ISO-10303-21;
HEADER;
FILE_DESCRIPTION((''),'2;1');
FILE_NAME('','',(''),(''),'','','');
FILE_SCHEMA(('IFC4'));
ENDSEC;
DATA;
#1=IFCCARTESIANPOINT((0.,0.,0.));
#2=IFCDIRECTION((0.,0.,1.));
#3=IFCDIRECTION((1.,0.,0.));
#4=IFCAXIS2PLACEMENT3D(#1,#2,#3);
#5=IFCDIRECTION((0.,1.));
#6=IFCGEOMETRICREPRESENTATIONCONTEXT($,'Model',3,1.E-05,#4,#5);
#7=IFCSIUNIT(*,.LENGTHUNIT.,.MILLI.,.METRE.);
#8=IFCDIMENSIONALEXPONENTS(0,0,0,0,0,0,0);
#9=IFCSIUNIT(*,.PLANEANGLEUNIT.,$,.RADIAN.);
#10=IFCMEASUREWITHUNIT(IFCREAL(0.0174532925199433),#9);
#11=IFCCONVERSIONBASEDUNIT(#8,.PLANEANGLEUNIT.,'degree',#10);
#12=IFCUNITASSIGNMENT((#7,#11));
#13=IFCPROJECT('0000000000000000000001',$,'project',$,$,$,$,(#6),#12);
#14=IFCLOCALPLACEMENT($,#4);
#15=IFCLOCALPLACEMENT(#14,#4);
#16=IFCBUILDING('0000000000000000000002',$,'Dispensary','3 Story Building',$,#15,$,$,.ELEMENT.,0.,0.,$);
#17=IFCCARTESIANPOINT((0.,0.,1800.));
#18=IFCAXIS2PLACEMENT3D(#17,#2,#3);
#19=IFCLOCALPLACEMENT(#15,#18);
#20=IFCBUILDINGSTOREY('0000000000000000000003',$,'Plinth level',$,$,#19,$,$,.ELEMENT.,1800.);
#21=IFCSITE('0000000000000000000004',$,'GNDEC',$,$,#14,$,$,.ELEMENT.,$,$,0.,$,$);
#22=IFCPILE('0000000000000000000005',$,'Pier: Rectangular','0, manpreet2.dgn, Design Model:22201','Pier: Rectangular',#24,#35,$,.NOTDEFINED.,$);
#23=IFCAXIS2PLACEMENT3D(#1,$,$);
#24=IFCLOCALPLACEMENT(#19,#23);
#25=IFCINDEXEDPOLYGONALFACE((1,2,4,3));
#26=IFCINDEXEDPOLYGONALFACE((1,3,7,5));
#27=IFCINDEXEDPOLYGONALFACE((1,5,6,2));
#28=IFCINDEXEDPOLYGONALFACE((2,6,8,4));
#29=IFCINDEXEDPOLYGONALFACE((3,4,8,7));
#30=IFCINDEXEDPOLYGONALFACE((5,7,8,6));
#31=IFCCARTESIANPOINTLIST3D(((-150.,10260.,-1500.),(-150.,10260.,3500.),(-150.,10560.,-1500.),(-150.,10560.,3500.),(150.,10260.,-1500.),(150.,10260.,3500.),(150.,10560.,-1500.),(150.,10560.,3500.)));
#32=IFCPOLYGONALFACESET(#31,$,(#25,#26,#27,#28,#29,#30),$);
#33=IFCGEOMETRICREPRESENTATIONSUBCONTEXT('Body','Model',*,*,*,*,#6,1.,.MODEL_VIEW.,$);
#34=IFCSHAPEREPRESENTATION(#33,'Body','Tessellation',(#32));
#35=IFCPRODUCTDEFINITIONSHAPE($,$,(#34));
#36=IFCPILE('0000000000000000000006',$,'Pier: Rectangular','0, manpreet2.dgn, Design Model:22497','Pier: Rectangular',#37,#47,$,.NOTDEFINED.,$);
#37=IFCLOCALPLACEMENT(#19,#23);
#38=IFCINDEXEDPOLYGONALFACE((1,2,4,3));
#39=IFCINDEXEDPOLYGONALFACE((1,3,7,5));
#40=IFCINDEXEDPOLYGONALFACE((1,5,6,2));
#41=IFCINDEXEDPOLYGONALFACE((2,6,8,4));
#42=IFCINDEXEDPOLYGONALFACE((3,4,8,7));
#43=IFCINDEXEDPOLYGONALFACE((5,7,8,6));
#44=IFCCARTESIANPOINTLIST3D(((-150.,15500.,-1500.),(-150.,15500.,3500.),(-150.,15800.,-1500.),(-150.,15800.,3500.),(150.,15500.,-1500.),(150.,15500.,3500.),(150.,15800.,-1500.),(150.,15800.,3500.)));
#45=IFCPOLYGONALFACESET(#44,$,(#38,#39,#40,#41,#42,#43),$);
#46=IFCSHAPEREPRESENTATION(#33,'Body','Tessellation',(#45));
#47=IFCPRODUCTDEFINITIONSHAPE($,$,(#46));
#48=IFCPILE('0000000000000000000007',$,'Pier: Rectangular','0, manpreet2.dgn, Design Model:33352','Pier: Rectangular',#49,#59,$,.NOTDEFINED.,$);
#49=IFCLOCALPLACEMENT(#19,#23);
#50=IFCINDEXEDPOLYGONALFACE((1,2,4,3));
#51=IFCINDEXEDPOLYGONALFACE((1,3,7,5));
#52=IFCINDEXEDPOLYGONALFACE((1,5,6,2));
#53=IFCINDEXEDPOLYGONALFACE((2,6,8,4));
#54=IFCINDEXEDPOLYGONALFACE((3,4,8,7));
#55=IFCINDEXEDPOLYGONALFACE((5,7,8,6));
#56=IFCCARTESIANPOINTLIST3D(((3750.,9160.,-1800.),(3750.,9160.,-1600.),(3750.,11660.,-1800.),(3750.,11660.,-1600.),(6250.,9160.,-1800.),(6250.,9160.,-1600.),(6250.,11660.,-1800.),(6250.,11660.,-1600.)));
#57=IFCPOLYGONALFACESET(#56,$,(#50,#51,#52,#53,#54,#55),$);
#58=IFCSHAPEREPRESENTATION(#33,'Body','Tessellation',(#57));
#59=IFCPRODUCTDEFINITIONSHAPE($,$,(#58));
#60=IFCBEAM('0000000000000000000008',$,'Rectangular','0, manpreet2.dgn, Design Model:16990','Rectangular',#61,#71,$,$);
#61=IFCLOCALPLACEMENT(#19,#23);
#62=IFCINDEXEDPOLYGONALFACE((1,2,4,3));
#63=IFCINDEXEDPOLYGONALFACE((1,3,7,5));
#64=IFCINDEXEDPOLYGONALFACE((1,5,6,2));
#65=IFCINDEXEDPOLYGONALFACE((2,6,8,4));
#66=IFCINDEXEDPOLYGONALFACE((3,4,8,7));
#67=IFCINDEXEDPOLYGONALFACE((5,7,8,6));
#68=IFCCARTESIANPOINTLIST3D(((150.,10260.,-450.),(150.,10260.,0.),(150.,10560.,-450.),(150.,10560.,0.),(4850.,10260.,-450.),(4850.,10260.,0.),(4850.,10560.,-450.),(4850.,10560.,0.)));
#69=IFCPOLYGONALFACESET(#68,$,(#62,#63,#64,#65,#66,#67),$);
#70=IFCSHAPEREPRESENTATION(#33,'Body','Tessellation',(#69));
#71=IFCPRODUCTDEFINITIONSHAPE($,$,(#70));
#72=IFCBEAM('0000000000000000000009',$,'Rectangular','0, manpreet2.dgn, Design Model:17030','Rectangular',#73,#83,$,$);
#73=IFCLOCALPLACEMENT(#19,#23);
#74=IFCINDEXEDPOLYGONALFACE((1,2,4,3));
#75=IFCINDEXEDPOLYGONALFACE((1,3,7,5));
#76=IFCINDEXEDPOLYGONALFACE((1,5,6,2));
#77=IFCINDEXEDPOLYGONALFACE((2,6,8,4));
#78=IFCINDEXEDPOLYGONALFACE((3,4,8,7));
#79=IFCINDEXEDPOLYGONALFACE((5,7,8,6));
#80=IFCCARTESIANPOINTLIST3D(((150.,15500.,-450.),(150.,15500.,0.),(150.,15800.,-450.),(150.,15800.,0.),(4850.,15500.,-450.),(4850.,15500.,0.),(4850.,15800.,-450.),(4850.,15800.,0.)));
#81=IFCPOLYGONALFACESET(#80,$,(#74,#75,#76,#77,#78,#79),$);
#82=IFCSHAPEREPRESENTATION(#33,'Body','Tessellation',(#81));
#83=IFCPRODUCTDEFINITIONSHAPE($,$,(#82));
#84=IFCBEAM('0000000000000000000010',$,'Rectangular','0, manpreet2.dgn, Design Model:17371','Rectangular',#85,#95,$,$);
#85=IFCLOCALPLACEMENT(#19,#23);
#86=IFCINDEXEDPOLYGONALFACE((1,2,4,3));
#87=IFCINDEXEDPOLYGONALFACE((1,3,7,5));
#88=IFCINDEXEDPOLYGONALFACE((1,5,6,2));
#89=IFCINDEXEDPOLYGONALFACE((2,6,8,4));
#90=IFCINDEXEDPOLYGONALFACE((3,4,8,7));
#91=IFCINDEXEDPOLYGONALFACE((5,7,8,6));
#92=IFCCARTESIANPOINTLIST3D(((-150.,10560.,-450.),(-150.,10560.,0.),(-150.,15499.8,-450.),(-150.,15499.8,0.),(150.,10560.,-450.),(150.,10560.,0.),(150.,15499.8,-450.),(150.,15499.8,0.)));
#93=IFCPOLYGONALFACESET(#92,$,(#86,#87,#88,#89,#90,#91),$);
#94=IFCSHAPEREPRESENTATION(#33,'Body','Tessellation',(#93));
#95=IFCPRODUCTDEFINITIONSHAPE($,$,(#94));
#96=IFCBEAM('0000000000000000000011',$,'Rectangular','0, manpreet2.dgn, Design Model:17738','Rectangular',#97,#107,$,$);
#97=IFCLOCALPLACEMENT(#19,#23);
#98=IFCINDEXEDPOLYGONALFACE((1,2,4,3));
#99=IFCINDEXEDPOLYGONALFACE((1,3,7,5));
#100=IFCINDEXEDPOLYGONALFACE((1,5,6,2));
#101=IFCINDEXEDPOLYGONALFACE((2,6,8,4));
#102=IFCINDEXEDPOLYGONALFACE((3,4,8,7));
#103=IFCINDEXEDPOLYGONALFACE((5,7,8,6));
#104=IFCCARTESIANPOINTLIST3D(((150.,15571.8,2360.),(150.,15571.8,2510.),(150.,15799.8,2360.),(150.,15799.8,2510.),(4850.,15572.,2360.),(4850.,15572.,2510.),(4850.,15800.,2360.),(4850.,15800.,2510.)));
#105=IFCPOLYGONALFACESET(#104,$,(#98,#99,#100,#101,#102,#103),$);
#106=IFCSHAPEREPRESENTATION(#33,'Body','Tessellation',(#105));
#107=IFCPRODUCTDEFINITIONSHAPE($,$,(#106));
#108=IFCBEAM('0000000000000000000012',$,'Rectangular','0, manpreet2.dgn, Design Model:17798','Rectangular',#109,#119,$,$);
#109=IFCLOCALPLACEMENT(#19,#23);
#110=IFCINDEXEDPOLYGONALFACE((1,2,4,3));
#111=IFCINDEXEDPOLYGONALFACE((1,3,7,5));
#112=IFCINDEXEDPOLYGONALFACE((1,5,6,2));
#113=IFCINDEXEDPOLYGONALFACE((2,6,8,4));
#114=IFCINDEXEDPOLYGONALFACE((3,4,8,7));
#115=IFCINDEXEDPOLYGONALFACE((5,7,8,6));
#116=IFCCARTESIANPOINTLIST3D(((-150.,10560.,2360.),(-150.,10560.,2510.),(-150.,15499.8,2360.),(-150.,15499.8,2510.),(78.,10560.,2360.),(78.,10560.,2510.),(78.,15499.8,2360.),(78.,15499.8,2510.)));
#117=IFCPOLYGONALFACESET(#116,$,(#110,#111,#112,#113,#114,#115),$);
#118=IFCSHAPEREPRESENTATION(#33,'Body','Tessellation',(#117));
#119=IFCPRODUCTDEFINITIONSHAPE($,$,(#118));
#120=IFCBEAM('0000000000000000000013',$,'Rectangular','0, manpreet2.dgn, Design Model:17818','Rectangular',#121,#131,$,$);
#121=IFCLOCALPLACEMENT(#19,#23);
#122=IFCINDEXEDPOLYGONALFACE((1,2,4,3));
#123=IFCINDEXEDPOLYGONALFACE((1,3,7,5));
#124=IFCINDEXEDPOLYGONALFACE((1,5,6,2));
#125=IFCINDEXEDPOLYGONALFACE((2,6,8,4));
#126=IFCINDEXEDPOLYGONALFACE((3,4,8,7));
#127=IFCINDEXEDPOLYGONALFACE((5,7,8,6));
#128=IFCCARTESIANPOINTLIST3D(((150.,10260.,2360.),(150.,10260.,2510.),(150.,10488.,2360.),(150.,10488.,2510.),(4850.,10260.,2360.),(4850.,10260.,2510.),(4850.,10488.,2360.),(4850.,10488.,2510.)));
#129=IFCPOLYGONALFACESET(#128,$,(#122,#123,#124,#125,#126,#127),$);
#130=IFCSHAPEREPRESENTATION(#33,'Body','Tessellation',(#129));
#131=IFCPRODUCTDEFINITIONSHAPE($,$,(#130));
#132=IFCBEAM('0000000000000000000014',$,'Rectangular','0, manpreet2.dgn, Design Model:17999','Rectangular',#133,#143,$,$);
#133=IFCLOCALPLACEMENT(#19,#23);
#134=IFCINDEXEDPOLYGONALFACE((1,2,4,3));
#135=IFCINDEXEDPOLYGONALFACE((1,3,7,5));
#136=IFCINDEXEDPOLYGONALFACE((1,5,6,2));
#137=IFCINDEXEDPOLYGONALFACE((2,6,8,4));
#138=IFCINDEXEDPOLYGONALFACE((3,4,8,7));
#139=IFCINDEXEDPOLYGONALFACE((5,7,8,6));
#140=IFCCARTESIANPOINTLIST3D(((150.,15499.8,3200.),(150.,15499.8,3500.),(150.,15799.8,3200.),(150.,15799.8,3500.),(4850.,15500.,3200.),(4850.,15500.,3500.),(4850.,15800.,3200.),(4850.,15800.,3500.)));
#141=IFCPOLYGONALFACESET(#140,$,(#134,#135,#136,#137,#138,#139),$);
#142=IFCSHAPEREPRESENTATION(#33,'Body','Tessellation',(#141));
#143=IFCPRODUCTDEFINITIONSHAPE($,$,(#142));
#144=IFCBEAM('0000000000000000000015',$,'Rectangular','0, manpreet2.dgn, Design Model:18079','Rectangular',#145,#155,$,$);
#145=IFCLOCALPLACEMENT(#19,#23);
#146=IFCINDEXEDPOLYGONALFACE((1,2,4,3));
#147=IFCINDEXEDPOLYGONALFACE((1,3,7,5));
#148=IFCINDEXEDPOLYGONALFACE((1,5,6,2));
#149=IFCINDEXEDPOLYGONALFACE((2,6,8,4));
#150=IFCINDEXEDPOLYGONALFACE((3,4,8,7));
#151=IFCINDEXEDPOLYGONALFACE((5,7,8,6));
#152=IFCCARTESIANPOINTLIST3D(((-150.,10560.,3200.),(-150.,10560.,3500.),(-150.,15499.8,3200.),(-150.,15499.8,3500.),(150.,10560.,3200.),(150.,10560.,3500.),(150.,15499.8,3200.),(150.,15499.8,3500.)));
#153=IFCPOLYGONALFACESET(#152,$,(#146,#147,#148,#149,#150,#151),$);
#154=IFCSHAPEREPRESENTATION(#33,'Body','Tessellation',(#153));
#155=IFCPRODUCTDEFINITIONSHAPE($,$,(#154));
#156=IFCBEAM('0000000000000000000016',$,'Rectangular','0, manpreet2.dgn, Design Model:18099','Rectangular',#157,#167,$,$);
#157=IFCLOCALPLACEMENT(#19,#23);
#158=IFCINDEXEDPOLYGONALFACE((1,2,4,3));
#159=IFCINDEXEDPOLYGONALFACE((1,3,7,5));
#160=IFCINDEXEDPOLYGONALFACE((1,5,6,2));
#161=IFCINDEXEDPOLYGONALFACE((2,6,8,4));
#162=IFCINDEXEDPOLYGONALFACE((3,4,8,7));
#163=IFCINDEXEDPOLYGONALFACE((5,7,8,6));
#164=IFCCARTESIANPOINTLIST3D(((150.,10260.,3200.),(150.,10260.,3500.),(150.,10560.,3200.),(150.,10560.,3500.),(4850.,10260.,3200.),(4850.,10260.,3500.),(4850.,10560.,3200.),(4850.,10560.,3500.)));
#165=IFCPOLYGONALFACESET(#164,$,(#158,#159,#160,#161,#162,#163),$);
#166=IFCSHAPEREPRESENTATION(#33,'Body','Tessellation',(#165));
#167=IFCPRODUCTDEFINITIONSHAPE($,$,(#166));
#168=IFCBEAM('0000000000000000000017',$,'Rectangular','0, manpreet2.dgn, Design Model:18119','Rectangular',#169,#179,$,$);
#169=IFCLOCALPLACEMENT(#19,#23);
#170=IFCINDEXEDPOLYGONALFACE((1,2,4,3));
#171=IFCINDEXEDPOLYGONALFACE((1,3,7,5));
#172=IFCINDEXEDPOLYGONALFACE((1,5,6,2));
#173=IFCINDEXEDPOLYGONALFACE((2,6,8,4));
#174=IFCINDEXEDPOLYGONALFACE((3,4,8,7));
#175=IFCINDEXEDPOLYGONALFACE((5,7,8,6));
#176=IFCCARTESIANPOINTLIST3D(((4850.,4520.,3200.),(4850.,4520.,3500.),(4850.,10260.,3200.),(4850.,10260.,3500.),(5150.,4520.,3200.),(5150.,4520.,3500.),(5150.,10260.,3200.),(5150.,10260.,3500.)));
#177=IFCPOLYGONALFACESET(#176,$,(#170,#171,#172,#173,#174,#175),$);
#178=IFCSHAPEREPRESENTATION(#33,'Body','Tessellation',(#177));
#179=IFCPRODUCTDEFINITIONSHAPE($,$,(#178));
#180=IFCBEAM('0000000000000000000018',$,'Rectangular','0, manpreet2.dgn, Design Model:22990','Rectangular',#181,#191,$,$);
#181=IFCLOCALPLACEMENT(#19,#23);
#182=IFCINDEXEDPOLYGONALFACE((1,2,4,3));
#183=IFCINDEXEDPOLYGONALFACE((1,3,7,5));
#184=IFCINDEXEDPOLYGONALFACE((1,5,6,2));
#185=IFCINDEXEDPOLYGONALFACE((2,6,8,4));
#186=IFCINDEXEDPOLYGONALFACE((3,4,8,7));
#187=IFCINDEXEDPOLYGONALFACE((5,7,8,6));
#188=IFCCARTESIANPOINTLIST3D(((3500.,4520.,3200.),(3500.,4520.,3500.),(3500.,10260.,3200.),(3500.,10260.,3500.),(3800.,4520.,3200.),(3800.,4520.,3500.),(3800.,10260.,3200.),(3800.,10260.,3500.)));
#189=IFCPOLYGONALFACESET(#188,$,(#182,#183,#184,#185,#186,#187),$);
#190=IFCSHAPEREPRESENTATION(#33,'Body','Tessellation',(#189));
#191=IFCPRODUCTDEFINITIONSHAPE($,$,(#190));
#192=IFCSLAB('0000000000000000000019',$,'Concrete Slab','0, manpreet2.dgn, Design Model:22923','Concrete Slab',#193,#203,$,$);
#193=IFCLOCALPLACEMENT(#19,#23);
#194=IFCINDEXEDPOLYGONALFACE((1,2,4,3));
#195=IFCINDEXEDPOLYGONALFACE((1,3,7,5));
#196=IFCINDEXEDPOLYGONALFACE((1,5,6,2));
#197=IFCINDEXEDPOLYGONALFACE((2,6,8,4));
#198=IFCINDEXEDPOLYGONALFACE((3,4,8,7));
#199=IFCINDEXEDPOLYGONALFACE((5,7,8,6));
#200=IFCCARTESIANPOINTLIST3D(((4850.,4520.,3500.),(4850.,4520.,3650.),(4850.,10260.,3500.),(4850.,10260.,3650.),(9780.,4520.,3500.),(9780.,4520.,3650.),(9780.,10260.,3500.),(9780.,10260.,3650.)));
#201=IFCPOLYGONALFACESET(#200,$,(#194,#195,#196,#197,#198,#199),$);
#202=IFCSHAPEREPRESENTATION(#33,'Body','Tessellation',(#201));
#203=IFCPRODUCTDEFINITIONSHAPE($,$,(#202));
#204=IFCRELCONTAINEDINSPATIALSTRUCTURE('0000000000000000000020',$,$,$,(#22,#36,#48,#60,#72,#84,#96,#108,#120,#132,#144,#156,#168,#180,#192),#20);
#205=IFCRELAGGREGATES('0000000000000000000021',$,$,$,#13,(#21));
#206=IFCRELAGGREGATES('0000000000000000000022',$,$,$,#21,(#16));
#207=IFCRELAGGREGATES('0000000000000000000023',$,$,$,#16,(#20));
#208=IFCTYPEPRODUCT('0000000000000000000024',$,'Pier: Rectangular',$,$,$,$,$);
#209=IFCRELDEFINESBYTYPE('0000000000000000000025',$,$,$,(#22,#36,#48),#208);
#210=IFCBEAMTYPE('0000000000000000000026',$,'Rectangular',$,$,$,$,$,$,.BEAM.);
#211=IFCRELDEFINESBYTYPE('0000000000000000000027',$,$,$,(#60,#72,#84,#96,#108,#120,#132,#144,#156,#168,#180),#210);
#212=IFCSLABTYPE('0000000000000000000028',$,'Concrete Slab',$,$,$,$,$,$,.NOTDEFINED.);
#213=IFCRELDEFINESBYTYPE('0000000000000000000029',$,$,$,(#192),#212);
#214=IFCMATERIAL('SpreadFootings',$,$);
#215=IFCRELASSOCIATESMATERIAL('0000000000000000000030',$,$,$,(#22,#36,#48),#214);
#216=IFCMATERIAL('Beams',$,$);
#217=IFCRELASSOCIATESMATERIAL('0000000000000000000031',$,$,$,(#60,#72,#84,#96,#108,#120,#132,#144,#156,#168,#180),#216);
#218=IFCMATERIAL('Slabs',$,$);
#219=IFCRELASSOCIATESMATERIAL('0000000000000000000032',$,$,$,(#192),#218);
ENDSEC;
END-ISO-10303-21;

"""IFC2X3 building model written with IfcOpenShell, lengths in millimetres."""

from ifc_helpers import new_model, entity, si_unit, converted_unit, direction, frame, frame_2d, origin_with_axes, place, context, subcontext, project, spatial, rectangle, extrude, material, type_object, element, save


model = new_model("IFC2X3")

# Units and contexts
model_context = context("Model", 3, precision=1e-05, world=origin_with_axes(), true_north=direction((0.0, 1.0)))
body_context = subcontext(model_context, "Body", "Model", "MODEL_VIEW", scale=1.0)
ifc_project = project(units=[si_unit("LENGTHUNIT", "METRE", prefix="MILLI"), converted_unit("PLANEANGLEUNIT", "degree", entity("IfcReal", 0.0174532925199433), si_unit("PLANEANGLEUNIT", "RADIAN"), dimensions=[0, 0, 0, 0, 0, 0, 0])], contexts=[model_context])

# Site, building, storey
site_placement = place(None, origin_with_axes())
site = spatial("IfcSite", under=ifc_project, at=site_placement, Name="GNDEC", CompositionType="ELEMENT", RefElevation=0.0)
building_placement = place(site_placement, origin_with_axes())
building = spatial("IfcBuilding", under=site, at=building_placement, Name="Dispensary", Description="3 Story Building", CompositionType="ELEMENT", ElevationOfRefHeight=0.0, ElevationOfTerrain=0.0)
storey_placement = place(building_placement, frame((0.0, 0.0, 1800.0), z_axis=(0.0, 0.0, 1.0), x_axis=(1.0, 0.0, 0.0)))
storey = spatial("IfcBuildingStorey", under=building, at=storey_placement, Name="Plinth level", CompositionType="ELEMENT", Elevation=1800.0)

# Piles
ifc_material_1 = material(Name="SpreadFootings")
type_product = type_object("IfcTypeProduct", Name="Pier: Rectangular")
for number, where, z_axis, x_axis, name, description in (
    (1, (-150.0, 10560.0, -1500.0), (0.0, 0.0, 1.0), (0.0, -1.0, 0.0), "Pier: Rectangular", "0, manpreet2.dgn, Design Model:22201"),
    (2, (-150.0, 15800.0, -1500.0), (0.0, 0.0, 1.0), (0.0, -1.0, 0.0), "Pier: Rectangular", "0, manpreet2.dgn, Design Model:22497"),
):
    element("IfcPile", number, at=place(storey_placement, frame(where, z_axis=z_axis, x_axis=x_axis)), inside=storey, type_object=type_product, material=ifc_material_1, Name=name, Description=description, ObjectType="Pier: Rectangular", PredefinedType="NOTDEFINED", context=body_context, shape_type="SweptSolid", body=[
        extrude(rectangle(XDim=300.0, YDim=300.0, at=frame_2d((150.0, 150.0), x_axis=(0.0, 1.0))), origin_with_axes(), (0.0, 0.0, 1.0), 5000.0),
    ])
for number, where, z_axis, x_axis, name in (
    (3, (3750.0, 11660.0, -1800.0), (0.0, 0.0, 1.0), (0.0, -1.0, 0.0), "Pier: Rectangular"),
):
    element("IfcPile", number, at=place(storey_placement, frame(where, z_axis=z_axis, x_axis=x_axis)), inside=storey, type_object=type_product, material=ifc_material_1, Name=name, Description="0, manpreet2.dgn, Design Model:33352", ObjectType="Pier: Rectangular", PredefinedType="NOTDEFINED", context=body_context, shape_type="SweptSolid", body=[
        extrude(rectangle(XDim=2500.0, YDim=2500.0, at=frame_2d((1250.0, 1250.0), x_axis=(0.0, 1.0))), origin_with_axes(), (0.0, 0.0, 1.0), 200.0),
    ])

# Beams
ifc_material_2 = material(Name="Beams")
beam_type = type_object("IfcBeamType", Name="Rectangular", PredefinedType="BEAM")
for number, where, z_axis, x_axis, name, description in (
    (4, (150.0, 10560.0, -450.0), (1.0, 0.0, 0.0), (0.0, 0.0, 1.0), "Rectangular", "0, manpreet2.dgn, Design Model:16990"),
    (5, (150.0, 15800.0, -450.0), (1.0, 0.0, 0.0), (0.0, 0.0, 1.0), "Rectangular", "0, manpreet2.dgn, Design Model:17030"),
):
    element("IfcBeam", number, at=place(storey_placement, frame(where, z_axis=z_axis, x_axis=x_axis)), inside=storey, type_object=beam_type, material=ifc_material_2, Name=name, Description=description, ObjectType="Rectangular", context=body_context, shape_type="SweptSolid", body=[
        extrude(rectangle(XDim=300.0, YDim=450.0, at=frame_2d((225.0, 150.0), x_axis=(0.0, 1.0))), origin_with_axes(), (0.0, 0.0, 1.0), 4700.0),
    ])
beam_1_placement = place(storey_placement, frame((150.0, 15499.8, -450.0), z_axis=(0.0, -1.0, 0.0), x_axis=(0.0, 0.0, 1.0)))
element("IfcBeam", 6, at=beam_1_placement, inside=storey, type_object=beam_type, material=ifc_material_2, Name="Rectangular", Description="0, manpreet2.dgn, Design Model:17371", ObjectType="Rectangular", context=body_context, shape_type="SweptSolid", body=[
    extrude(rectangle(XDim=300.0, YDim=450.0, at=frame_2d((225.0, 150.0), x_axis=(0.0, 1.0))), origin_with_axes(), (0.0, 0.0, 1.0), 4939.8),
])
beam_2_placement = place(storey_placement, frame((150.0, 15571.8, 2360.0), z_axis=(1.0, 0.000049, 0.0), x_axis=(-0.000049, 1.0, 0.0)))
element("IfcBeam", 7, at=beam_2_placement, inside=storey, type_object=beam_type, material=ifc_material_2, Name="Rectangular", Description="0, manpreet2.dgn, Design Model:17738", ObjectType="Rectangular", context=body_context, shape_type="SweptSolid", body=[
    extrude(rectangle(XDim=150.0, YDim=228.0, at=frame_2d((114.0, 75.0), x_axis=(0.0, 1.0))), origin_with_axes(), (0.0, 0.0, 1.0), 4700.0),
])
beam_3_placement = place(storey_placement, frame((78.0, 10560.0, 2360.0), z_axis=(0.0, 1.0, 0.0), x_axis=(-1.0, 0.0, 0.0)))
element("IfcBeam", 8, at=beam_3_placement, inside=storey, type_object=beam_type, material=ifc_material_2, Name="Rectangular", Description="0, manpreet2.dgn, Design Model:17798", ObjectType="Rectangular", context=body_context, shape_type="SweptSolid", body=[
    extrude(rectangle(XDim=150.0, YDim=228.0, at=frame_2d((114.0, 75.0), x_axis=(0.0, 1.0))), origin_with_axes(), (0.0, 0.0, 1.0), 4939.8),
])
beam_4_placement = place(storey_placement, frame((4850.0, 10488.0, 2360.0), z_axis=(-1.0, 0.0, 0.0), x_axis=(0.0, -1.0, 0.0)))
element("IfcBeam", 9, at=beam_4_placement, inside=storey, type_object=beam_type, material=ifc_material_2, Name="Rectangular", Description="0, manpreet2.dgn, Design Model:17818", ObjectType="Rectangular", context=body_context, shape_type="SweptSolid", body=[
    extrude(rectangle(XDim=150.0, YDim=228.0, at=frame_2d((114.0, 75.0), x_axis=(0.0, 1.0))), origin_with_axes(), (0.0, 0.0, 1.0), 4700.0),
])
beam_5_placement = place(storey_placement, frame((150.0, 15499.8, 3200.0), z_axis=(1.0, 0.000049, 0.0), x_axis=(-0.000049, 1.0, 0.0)))
element("IfcBeam", 10, at=beam_5_placement, inside=storey, type_object=beam_type, material=ifc_material_2, Name="Rectangular", Description="0, manpreet2.dgn, Design Model:17999", ObjectType="Rectangular", context=body_context, shape_type="SweptSolid", body=[
    extrude(rectangle(XDim=300.0, YDim=300.0, at=frame_2d((150.0, 150.0), x_axis=(0.0, 1.0))), origin_with_axes(), (0.0, 0.0, 1.0), 4700.0),
])
beam_6_placement = place(storey_placement, frame((-150.0, 15499.8, 3200.0), z_axis=(0.0, -1.0, 0.0), x_axis=(1.0, 0.0, 0.0)))
element("IfcBeam", 11, at=beam_6_placement, inside=storey, type_object=beam_type, material=ifc_material_2, Name="Rectangular", Description="0, manpreet2.dgn, Design Model:18079", ObjectType="Rectangular", context=body_context, shape_type="SweptSolid", body=[
    extrude(rectangle(XDim=300.0, YDim=300.0, at=frame_2d((150.0, 150.0), x_axis=(0.0, 1.0))), origin_with_axes(), (0.0, 0.0, 1.0), 4939.8),
])
beam_7_placement = place(storey_placement, frame((150.0, 10260.0, 3200.0), z_axis=(1.0, 0.0, 0.0), x_axis=(0.0, 1.0, 0.0)))
element("IfcBeam", 12, at=beam_7_placement, inside=storey, type_object=beam_type, material=ifc_material_2, Name="Rectangular", Description="0, manpreet2.dgn, Design Model:18099", ObjectType="Rectangular", context=body_context, shape_type="SweptSolid", body=[
    extrude(rectangle(XDim=300.0, YDim=300.0, at=frame_2d((150.0, 150.0), x_axis=(0.0, 1.0))), origin_with_axes(), (0.0, 0.0, 1.0), 4700.0),
])
for number, where, z_axis, x_axis, name, description in (
    (13, (4850.0, 10260.0, 3200.0), (0.0, -1.0, 0.0), (1.0, 0.0, 0.0), "Rectangular", "0, manpreet2.dgn, Design Model:18119"),
    (14, (3500.0, 10260.0, 3200.0), (0.0, -1.0, 0.0), (1.0, 0.0, 0.0), "Rectangular", "0, manpreet2.dgn, Design Model:22990"),
):
    element("IfcBeam", number, at=place(storey_placement, frame(where, z_axis=z_axis, x_axis=x_axis)), inside=storey, type_object=beam_type, material=ifc_material_2, Name=name, Description=description, ObjectType="Rectangular", context=body_context, shape_type="SweptSolid", body=[
        extrude(rectangle(XDim=300.0, YDim=300.0, at=frame_2d((150.0, 150.0), x_axis=(0.0, 1.0))), origin_with_axes(), (0.0, 0.0, 1.0), 5740.0),
    ])

# Slab
ifc_material_3 = material(Name="Slabs")
slab_type = type_object("IfcSlabType", Name="Concrete Slab", PredefinedType="NOTDEFINED")
slab_1_placement = place(storey_placement, frame((4850.0, 10260.0, 3500.0), z_axis=(0.0, 0.0, 1.0), x_axis=(0.0, -1.0, 0.0)))
element("IfcSlab", 15, at=slab_1_placement, inside=storey, type_object=slab_type, material=ifc_material_3, Name="Concrete Slab", Description="0, manpreet2.dgn, Design Model:22923", ObjectType="Concrete Slab", context=body_context, shape_type="SweptSolid", body=[
    extrude(rectangle(XDim=5740.0, YDim=4930.0, at=frame_2d((2870.0, 2465.0), x_axis=(1.0, 0.0))), origin_with_axes(), (0.0, 0.0, 1.0), 150.0),
])

save(model, "model.ifc")
